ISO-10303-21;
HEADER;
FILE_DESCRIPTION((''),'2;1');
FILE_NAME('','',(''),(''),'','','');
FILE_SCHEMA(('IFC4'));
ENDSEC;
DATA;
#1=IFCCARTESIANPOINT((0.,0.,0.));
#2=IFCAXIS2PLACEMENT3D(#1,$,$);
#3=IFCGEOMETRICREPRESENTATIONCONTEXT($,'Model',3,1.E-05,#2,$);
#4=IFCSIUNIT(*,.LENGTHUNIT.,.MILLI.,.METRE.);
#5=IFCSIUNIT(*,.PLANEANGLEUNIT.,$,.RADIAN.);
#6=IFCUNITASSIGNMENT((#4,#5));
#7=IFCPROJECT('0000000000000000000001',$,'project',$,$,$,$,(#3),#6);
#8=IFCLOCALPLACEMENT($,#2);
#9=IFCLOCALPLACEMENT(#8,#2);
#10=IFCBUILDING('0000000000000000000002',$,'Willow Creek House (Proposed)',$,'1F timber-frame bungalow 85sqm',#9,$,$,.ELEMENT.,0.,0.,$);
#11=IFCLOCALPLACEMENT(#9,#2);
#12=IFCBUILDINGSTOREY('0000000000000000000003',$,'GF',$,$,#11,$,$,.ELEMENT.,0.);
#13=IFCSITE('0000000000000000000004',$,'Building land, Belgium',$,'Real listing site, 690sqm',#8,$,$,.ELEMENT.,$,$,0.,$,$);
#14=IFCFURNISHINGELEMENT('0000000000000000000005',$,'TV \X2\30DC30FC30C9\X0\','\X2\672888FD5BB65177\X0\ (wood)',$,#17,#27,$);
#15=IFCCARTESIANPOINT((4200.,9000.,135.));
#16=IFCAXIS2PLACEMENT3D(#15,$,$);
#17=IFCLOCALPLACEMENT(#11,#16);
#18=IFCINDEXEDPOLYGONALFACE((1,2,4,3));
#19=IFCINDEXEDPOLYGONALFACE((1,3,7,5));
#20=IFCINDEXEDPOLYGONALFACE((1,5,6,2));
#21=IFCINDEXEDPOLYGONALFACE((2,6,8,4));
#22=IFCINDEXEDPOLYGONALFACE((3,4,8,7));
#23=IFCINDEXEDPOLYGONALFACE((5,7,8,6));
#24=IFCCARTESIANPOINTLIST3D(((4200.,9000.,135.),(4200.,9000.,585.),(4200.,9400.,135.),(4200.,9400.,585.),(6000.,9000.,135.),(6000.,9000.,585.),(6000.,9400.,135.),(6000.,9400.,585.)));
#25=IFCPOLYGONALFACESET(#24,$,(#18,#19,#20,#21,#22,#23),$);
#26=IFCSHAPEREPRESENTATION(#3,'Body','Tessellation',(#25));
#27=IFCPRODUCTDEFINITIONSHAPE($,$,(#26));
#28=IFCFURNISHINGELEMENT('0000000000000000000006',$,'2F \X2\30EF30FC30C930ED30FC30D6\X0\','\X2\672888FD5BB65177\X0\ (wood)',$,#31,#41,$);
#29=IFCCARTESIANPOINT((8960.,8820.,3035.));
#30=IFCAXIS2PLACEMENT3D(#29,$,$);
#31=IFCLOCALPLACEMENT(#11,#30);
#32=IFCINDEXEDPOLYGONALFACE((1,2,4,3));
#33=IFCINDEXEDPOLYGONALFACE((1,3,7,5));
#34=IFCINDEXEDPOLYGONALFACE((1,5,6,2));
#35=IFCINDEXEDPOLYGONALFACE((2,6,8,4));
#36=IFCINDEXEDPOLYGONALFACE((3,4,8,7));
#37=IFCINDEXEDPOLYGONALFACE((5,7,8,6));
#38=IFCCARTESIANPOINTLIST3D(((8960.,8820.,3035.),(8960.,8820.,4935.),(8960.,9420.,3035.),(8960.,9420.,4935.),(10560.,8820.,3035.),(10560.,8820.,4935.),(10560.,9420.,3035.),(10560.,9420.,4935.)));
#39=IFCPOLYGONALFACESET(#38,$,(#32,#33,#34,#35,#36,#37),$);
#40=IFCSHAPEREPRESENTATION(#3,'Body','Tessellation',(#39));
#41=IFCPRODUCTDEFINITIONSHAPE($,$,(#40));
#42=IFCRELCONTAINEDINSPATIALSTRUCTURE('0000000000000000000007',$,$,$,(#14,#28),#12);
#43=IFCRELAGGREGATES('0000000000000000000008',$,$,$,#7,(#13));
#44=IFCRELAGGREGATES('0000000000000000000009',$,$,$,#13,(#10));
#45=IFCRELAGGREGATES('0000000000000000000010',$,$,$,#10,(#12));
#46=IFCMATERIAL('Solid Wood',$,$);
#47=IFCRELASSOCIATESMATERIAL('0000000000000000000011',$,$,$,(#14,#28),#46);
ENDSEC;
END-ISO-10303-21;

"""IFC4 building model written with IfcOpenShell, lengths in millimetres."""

from ifc_helpers import new_model, si_unit, frame, frame_2d, origin, place, context, project, spatial, rectangle, extrude, material, element, save


model = new_model("IFC4")

# Units and contexts
model_context = context("Model", 3, precision=1e-05, world=origin())
ifc_project = project(units=[si_unit("LENGTHUNIT", "METRE", prefix="MILLI"), si_unit("PLANEANGLEUNIT", "RADIAN")], contexts=[model_context])

# Site, building, storey
site_placement = place(None, origin())
site = spatial("IfcSite", under=ifc_project, at=site_placement, Name="Building land, Belgium", ObjectType="Real listing site, 690sqm", CompositionType="ELEMENT", RefElevation=0.0)
building_placement = place(site_placement, origin())
building = spatial("IfcBuilding", under=site, at=building_placement, Name="Willow Creek House (Proposed)", ObjectType="1F timber-frame bungalow 85sqm", CompositionType="ELEMENT", ElevationOfRefHeight=0.0, ElevationOfTerrain=0.0)
storey_placement = place(building_placement, origin())
storey = spatial("IfcBuildingStorey", under=building, at=storey_placement, Name="GF", CompositionType="ELEMENT", Elevation=0.0)

# Shared definitions
ifc_material_1 = material(Name="Solid Wood")

# Furnishing elements
furnishing_1_placement = place(storey_placement, frame((4200.0, 9000.0, 135.0)))
element("IfcFurnishingElement", 1, at=furnishing_1_placement, inside=storey, material=ifc_material_1, Name="TV ボード", Description="木製家具 (wood)", context=model_context, shape_type="SweptSolid", body=[
    extrude(rectangle(XDim=1800.0, YDim=400.0, at=frame_2d((900.0, 200.0))), frame((4200.0, 9000.0, 135.0)), (0.0, 0.0, 1.0), 450.0),
])
furnishing_2_placement = place(storey_placement, frame((8960.0, 8820.0, 3035.0)))
element("IfcFurnishingElement", 2, at=furnishing_2_placement, inside=storey, material=ifc_material_1, Name="2F ワードローブ", Description="木製家具 (wood)", context=model_context, shape_type="SweptSolid", body=[
    extrude(rectangle(XDim=1600.0, YDim=600.0, at=frame_2d((800.0, 300.0))), frame((8960.0, 8820.0, 3035.0)), (0.0, 0.0, 1.0), 1900.0),
])

save(model, "model.ifc")
